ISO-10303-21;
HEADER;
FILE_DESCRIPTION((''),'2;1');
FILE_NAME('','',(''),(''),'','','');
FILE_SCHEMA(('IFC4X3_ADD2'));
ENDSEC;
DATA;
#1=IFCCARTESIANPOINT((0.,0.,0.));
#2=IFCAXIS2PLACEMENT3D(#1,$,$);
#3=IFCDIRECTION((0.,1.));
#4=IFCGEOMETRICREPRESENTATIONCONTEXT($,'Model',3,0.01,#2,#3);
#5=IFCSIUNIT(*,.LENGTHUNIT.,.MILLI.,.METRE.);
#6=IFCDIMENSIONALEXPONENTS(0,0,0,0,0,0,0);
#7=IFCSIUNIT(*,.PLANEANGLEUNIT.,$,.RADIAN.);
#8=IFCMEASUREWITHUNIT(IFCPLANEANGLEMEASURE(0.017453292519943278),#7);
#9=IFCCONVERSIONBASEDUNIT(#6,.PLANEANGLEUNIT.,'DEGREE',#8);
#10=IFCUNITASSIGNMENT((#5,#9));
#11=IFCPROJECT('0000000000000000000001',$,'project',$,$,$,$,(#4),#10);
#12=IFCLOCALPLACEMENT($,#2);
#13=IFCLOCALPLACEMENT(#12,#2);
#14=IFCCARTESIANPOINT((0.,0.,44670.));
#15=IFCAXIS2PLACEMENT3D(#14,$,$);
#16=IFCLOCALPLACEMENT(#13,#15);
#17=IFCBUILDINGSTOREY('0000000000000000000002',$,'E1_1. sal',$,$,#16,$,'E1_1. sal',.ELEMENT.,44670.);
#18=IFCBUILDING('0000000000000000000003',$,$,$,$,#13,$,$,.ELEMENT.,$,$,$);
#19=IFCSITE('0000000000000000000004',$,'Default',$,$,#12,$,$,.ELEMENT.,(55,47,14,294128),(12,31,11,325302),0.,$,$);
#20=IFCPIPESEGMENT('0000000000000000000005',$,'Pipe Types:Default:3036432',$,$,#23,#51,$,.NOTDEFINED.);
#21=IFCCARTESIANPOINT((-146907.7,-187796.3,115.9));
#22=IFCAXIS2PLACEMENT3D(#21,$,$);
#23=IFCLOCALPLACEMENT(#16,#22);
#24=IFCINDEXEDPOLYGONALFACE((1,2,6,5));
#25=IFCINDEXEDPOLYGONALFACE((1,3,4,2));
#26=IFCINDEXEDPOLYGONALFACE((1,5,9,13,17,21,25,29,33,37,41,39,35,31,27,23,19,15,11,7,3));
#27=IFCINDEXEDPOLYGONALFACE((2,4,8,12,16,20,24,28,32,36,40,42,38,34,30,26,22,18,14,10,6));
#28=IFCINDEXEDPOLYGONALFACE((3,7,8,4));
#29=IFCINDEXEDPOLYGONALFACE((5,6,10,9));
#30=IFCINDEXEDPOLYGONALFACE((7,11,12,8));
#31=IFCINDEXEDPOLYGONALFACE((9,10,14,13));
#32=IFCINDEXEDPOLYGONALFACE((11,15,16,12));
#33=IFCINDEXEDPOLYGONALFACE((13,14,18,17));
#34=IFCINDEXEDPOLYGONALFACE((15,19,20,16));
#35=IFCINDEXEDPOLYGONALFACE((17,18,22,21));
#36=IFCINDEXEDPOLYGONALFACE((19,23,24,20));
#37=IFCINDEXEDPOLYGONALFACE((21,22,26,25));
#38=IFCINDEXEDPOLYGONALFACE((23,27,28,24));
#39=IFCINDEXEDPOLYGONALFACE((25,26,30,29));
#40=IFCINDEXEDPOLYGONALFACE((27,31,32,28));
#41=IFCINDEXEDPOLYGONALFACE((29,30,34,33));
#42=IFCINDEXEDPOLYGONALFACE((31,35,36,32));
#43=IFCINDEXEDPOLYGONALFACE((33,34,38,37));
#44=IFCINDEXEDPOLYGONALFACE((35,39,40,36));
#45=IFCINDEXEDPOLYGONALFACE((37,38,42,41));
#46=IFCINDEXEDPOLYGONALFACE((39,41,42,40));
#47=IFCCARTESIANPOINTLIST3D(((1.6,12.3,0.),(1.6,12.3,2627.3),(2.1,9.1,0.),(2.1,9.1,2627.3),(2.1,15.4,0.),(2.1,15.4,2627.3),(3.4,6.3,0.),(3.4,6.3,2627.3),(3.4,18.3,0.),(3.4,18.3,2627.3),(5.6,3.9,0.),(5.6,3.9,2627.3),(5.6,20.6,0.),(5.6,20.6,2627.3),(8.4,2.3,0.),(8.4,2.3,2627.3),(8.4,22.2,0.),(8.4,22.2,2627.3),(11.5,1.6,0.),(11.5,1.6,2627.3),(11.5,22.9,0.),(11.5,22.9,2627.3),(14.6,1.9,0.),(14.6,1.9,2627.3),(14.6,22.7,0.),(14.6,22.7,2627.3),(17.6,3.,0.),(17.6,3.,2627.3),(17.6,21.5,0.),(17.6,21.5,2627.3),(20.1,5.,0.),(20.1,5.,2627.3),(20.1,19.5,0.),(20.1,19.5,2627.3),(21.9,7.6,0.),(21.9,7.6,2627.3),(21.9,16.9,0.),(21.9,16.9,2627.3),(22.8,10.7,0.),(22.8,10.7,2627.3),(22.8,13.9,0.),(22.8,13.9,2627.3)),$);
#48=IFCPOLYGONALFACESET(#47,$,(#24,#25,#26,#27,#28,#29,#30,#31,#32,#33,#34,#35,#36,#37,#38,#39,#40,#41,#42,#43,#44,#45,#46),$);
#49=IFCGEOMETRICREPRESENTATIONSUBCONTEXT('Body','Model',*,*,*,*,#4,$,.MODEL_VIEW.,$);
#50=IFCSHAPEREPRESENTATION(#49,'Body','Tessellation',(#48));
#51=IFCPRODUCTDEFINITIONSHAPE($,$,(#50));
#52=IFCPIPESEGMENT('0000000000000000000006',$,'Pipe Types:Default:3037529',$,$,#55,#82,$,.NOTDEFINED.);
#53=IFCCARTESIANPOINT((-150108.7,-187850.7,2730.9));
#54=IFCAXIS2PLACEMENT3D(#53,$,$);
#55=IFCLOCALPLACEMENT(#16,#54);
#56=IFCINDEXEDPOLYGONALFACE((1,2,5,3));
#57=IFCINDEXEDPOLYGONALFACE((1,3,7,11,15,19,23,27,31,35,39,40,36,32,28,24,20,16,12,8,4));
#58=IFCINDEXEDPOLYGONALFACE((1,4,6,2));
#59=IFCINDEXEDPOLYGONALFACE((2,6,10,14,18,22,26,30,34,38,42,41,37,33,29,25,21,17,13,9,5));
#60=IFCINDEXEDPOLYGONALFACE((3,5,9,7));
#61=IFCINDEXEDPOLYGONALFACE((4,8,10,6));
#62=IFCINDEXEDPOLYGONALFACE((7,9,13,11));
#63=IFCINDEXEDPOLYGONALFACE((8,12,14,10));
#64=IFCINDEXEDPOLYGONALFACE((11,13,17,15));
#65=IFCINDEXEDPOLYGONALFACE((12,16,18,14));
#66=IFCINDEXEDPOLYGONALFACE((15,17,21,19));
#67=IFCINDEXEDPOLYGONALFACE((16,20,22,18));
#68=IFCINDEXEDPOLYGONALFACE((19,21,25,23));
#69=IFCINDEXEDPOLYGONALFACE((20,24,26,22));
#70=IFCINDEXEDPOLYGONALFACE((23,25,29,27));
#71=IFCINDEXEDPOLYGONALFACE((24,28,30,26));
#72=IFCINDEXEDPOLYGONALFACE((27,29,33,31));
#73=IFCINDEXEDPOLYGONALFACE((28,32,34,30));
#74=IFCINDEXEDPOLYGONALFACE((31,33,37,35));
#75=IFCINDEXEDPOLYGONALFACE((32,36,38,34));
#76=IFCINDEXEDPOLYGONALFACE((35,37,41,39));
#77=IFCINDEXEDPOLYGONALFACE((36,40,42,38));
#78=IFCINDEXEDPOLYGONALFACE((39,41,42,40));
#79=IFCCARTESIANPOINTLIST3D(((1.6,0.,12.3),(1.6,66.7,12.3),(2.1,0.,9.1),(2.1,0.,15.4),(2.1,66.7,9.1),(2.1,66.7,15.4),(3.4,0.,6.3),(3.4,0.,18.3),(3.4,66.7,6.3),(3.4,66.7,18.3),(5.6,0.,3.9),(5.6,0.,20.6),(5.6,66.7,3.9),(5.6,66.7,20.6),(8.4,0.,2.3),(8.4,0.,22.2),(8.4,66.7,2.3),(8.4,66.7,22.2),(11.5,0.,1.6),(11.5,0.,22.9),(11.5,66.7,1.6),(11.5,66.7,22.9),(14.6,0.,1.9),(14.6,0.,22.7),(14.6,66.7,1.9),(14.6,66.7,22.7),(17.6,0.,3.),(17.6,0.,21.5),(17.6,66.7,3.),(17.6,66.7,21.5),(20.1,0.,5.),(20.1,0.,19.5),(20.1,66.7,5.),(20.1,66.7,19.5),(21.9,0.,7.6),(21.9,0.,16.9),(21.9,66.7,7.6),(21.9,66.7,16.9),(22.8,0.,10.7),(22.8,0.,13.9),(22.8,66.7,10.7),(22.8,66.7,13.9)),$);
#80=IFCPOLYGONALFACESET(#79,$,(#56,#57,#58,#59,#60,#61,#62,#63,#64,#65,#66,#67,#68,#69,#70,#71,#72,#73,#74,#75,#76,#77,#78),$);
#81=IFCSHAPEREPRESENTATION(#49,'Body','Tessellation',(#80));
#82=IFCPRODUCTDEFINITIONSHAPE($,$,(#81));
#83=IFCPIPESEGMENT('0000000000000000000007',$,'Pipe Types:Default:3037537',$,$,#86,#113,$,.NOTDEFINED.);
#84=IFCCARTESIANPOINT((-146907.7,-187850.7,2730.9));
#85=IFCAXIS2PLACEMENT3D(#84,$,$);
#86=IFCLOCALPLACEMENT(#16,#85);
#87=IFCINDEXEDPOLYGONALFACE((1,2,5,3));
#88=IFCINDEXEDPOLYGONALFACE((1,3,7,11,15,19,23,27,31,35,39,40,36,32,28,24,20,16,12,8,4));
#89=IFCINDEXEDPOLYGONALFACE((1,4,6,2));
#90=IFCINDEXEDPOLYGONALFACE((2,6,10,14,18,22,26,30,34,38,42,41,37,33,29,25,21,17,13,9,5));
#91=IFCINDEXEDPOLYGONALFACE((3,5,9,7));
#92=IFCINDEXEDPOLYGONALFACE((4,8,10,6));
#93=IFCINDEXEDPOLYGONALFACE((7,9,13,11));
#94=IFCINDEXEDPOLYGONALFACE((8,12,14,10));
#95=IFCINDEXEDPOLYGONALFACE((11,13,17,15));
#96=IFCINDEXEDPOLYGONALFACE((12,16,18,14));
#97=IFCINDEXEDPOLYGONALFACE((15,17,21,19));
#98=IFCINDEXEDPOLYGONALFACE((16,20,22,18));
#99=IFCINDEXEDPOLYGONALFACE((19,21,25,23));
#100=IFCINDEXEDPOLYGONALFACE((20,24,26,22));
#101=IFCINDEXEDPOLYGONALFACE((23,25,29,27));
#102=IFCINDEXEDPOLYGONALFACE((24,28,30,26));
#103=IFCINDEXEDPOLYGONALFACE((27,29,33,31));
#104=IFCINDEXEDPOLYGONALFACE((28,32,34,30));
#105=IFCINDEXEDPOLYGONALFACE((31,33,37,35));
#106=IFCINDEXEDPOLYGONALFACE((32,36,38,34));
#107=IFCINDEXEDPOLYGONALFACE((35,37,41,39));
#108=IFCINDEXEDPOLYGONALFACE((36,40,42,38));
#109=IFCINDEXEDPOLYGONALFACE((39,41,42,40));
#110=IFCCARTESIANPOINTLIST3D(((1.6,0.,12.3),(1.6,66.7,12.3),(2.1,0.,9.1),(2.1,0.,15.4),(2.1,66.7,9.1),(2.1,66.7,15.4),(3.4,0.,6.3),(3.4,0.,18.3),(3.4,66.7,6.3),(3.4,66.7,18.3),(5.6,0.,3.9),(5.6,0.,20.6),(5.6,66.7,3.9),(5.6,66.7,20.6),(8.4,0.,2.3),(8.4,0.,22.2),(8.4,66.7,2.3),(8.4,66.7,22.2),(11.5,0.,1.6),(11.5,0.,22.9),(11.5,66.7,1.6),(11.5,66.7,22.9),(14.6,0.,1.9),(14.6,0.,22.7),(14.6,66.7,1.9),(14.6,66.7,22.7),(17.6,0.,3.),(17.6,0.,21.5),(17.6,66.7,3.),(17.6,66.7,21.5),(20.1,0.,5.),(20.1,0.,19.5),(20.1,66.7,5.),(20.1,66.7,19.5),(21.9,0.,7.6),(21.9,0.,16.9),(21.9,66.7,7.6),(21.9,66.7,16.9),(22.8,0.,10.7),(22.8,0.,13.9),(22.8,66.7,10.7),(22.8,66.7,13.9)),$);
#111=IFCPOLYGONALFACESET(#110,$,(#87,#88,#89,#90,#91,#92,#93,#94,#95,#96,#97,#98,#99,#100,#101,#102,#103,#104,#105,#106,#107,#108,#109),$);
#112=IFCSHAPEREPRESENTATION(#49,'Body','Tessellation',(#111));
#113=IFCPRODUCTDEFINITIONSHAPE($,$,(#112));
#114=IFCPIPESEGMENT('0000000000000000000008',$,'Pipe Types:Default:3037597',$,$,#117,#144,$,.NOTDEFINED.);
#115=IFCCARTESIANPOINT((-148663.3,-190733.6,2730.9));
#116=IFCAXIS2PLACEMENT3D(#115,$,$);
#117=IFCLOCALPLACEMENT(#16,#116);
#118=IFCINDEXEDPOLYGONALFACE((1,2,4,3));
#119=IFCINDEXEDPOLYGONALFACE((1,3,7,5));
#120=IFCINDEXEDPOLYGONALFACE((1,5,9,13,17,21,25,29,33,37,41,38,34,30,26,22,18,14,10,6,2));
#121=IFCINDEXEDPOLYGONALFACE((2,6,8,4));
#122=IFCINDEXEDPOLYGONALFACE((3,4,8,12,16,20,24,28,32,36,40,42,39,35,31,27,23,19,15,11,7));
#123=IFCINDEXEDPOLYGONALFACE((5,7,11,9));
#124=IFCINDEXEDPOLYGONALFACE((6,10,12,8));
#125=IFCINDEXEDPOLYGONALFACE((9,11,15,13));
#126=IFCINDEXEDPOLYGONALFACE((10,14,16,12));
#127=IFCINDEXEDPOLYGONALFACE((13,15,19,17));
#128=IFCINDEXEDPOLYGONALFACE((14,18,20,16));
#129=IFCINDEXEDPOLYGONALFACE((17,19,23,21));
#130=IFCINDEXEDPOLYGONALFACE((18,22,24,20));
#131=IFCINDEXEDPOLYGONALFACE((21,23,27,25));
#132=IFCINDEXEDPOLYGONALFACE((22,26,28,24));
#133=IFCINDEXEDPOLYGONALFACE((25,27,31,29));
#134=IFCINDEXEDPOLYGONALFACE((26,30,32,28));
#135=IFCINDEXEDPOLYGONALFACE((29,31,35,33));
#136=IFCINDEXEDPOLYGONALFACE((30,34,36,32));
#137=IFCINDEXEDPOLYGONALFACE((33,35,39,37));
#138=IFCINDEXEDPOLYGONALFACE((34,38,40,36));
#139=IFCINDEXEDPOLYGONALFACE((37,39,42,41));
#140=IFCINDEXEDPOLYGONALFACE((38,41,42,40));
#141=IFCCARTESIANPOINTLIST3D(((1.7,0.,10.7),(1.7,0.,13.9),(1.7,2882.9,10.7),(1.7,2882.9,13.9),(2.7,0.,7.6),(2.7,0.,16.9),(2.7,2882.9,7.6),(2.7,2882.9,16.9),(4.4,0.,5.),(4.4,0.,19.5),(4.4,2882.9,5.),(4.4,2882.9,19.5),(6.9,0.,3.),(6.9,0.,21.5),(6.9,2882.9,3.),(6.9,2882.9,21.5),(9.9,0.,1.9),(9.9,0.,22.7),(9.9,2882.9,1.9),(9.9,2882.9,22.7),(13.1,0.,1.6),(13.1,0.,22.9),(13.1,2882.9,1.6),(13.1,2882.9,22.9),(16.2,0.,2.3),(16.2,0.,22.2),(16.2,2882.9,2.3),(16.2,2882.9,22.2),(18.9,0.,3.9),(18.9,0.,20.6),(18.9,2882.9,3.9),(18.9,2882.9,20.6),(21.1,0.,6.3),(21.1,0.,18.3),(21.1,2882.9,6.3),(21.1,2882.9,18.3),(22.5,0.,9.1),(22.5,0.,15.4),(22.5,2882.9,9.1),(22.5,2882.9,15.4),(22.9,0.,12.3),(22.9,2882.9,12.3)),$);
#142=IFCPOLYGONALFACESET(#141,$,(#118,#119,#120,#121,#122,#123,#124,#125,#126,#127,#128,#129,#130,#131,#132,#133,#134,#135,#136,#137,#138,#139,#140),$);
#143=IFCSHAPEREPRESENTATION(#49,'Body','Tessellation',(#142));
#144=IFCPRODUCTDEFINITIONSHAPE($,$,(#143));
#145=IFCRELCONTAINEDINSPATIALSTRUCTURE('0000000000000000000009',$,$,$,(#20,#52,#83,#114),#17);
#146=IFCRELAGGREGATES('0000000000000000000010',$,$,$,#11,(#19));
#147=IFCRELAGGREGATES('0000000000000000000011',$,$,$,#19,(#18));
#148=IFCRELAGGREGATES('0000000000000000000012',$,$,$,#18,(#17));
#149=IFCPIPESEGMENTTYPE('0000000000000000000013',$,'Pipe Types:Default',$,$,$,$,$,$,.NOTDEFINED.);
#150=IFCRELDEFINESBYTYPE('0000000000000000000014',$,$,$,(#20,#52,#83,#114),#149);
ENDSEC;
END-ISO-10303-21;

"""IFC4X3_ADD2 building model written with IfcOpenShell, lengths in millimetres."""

from ifc_helpers import new_model, entity, si_unit, converted_unit, direction, frame, frame_2d, origin, origin_2d_with_axis, place, context, subcontext, project, spatial, circle, extrude, type_object, element, save


model = new_model("IFC4X3_ADD2")

# Units and contexts
model_context = context("Model", 3, precision=0.01, world=origin(), true_north=direction((0.0, 1.0)))
body_context = subcontext(model_context, "Body", "Model", "MODEL_VIEW")
ifc_project = project(units=[si_unit("LENGTHUNIT", "METRE", prefix="MILLI"), converted_unit("PLANEANGLEUNIT", "DEGREE", entity("IfcPlaneAngleMeasure", 0.017453292519943278), si_unit("PLANEANGLEUNIT", "RADIAN"), dimensions=[0, 0, 0, 0, 0, 0, 0])], contexts=[model_context])

# Site, building, storey
site_placement = place(None, origin())
site = spatial("IfcSite", under=ifc_project, at=site_placement, Name="Default", CompositionType="ELEMENT", RefLatitude=(55, 47, 14, 294128), RefLongitude=(12, 31, 11, 325302), RefElevation=0.0)
building_placement = place(site_placement, origin())
building = spatial("IfcBuilding", under=site, at=building_placement, CompositionType="ELEMENT")
storey_placement = place(building_placement, frame((0.0, 0.0, 44670.0)))
storey = spatial("IfcBuildingStorey", under=building, at=storey_placement, Name="E1_1. sal", LongName="E1_1. sal", CompositionType="ELEMENT", Elevation=44670.0)

# Pipe segments
pipe_segment_type = type_object("IfcPipeSegmentType", Name="Pipe Types:Default", PredefinedType="NOTDEFINED")
for number, where, name in (
    (1, (-146907.7, -187796.3, 115.9), "Pipe Types:Default:3036432"),
):
    element("IfcPipeSegment", number, at=place(storey_placement, frame(where)), inside=storey, type_object=pipe_segment_type, Name=name, PredefinedType="NOTDEFINED", context=body_context, shape_type="SweptSolid", body=[
        extrude(circle(Radius=10.7, at=frame_2d((0.0, 0.0), x_axis=(1.0, 0.0))), frame((12.3, 12.3, 0.0), z_axis=(0.0, 0.0, 1.0), x_axis=(-1.0, 0.0, 0.0)), (0.0, 0.0, 1.0), 2627.3),
    ])
pipe_segment_1_placement = place(storey_placement, frame((-150108.7, -187850.7, 2730.9)))
element("IfcPipeSegment", 2, at=pipe_segment_1_placement, inside=storey, type_object=pipe_segment_type, Name="Pipe Types:Default:3037529", PredefinedType="NOTDEFINED", context=body_context, shape_type="SweptSolid", body=[
    extrude(circle(Radius=10.7, at=frame_2d((0.0, 0.0), x_axis=(1.0, 0.0))), frame((12.3, 0.0, 12.3), z_axis=(0.0, 1.0, 0.0), x_axis=(-1.0, 0.0, 0.0)), (0.0, 0.0, 1.0), 66.7),
])
pipe_segment_2_placement = place(storey_placement, frame((-146907.7, -187850.7, 2730.9)))
element("IfcPipeSegment", 3, at=pipe_segment_2_placement, inside=storey, type_object=pipe_segment_type, Name="Pipe Types:Default:3037537", PredefinedType="NOTDEFINED", context=body_context, shape_type="SweptSolid", body=[
    extrude(circle(Radius=10.7, at=frame_2d((0.0, 0.0), x_axis=(1.0, 0.0))), frame((12.3, 0.0, 12.3), z_axis=(0.0, 1.0, 0.0), x_axis=(-1.0, 0.0, 0.0)), (0.0, 0.0, 1.0), 66.7),
])
pipe_segment_3_placement = place(storey_placement, frame((-148663.3, -190733.6, 2730.9)))
element("IfcPipeSegment", 4, at=pipe_segment_3_placement, inside=storey, type_object=pipe_segment_type, Name="Pipe Types:Default:3037597", PredefinedType="NOTDEFINED", context=body_context, shape_type="SweptSolid", body=[
    extrude(circle(Radius=10.7, at=origin_2d_with_axis()), frame((12.3, 0.0, 12.3), z_axis=(0.0, 1.0, 0.0), x_axis=(1.0, 0.0, 0.0)), (0.0, 0.0, 1.0), 2882.9),
])

save(model, "model.ifc")
